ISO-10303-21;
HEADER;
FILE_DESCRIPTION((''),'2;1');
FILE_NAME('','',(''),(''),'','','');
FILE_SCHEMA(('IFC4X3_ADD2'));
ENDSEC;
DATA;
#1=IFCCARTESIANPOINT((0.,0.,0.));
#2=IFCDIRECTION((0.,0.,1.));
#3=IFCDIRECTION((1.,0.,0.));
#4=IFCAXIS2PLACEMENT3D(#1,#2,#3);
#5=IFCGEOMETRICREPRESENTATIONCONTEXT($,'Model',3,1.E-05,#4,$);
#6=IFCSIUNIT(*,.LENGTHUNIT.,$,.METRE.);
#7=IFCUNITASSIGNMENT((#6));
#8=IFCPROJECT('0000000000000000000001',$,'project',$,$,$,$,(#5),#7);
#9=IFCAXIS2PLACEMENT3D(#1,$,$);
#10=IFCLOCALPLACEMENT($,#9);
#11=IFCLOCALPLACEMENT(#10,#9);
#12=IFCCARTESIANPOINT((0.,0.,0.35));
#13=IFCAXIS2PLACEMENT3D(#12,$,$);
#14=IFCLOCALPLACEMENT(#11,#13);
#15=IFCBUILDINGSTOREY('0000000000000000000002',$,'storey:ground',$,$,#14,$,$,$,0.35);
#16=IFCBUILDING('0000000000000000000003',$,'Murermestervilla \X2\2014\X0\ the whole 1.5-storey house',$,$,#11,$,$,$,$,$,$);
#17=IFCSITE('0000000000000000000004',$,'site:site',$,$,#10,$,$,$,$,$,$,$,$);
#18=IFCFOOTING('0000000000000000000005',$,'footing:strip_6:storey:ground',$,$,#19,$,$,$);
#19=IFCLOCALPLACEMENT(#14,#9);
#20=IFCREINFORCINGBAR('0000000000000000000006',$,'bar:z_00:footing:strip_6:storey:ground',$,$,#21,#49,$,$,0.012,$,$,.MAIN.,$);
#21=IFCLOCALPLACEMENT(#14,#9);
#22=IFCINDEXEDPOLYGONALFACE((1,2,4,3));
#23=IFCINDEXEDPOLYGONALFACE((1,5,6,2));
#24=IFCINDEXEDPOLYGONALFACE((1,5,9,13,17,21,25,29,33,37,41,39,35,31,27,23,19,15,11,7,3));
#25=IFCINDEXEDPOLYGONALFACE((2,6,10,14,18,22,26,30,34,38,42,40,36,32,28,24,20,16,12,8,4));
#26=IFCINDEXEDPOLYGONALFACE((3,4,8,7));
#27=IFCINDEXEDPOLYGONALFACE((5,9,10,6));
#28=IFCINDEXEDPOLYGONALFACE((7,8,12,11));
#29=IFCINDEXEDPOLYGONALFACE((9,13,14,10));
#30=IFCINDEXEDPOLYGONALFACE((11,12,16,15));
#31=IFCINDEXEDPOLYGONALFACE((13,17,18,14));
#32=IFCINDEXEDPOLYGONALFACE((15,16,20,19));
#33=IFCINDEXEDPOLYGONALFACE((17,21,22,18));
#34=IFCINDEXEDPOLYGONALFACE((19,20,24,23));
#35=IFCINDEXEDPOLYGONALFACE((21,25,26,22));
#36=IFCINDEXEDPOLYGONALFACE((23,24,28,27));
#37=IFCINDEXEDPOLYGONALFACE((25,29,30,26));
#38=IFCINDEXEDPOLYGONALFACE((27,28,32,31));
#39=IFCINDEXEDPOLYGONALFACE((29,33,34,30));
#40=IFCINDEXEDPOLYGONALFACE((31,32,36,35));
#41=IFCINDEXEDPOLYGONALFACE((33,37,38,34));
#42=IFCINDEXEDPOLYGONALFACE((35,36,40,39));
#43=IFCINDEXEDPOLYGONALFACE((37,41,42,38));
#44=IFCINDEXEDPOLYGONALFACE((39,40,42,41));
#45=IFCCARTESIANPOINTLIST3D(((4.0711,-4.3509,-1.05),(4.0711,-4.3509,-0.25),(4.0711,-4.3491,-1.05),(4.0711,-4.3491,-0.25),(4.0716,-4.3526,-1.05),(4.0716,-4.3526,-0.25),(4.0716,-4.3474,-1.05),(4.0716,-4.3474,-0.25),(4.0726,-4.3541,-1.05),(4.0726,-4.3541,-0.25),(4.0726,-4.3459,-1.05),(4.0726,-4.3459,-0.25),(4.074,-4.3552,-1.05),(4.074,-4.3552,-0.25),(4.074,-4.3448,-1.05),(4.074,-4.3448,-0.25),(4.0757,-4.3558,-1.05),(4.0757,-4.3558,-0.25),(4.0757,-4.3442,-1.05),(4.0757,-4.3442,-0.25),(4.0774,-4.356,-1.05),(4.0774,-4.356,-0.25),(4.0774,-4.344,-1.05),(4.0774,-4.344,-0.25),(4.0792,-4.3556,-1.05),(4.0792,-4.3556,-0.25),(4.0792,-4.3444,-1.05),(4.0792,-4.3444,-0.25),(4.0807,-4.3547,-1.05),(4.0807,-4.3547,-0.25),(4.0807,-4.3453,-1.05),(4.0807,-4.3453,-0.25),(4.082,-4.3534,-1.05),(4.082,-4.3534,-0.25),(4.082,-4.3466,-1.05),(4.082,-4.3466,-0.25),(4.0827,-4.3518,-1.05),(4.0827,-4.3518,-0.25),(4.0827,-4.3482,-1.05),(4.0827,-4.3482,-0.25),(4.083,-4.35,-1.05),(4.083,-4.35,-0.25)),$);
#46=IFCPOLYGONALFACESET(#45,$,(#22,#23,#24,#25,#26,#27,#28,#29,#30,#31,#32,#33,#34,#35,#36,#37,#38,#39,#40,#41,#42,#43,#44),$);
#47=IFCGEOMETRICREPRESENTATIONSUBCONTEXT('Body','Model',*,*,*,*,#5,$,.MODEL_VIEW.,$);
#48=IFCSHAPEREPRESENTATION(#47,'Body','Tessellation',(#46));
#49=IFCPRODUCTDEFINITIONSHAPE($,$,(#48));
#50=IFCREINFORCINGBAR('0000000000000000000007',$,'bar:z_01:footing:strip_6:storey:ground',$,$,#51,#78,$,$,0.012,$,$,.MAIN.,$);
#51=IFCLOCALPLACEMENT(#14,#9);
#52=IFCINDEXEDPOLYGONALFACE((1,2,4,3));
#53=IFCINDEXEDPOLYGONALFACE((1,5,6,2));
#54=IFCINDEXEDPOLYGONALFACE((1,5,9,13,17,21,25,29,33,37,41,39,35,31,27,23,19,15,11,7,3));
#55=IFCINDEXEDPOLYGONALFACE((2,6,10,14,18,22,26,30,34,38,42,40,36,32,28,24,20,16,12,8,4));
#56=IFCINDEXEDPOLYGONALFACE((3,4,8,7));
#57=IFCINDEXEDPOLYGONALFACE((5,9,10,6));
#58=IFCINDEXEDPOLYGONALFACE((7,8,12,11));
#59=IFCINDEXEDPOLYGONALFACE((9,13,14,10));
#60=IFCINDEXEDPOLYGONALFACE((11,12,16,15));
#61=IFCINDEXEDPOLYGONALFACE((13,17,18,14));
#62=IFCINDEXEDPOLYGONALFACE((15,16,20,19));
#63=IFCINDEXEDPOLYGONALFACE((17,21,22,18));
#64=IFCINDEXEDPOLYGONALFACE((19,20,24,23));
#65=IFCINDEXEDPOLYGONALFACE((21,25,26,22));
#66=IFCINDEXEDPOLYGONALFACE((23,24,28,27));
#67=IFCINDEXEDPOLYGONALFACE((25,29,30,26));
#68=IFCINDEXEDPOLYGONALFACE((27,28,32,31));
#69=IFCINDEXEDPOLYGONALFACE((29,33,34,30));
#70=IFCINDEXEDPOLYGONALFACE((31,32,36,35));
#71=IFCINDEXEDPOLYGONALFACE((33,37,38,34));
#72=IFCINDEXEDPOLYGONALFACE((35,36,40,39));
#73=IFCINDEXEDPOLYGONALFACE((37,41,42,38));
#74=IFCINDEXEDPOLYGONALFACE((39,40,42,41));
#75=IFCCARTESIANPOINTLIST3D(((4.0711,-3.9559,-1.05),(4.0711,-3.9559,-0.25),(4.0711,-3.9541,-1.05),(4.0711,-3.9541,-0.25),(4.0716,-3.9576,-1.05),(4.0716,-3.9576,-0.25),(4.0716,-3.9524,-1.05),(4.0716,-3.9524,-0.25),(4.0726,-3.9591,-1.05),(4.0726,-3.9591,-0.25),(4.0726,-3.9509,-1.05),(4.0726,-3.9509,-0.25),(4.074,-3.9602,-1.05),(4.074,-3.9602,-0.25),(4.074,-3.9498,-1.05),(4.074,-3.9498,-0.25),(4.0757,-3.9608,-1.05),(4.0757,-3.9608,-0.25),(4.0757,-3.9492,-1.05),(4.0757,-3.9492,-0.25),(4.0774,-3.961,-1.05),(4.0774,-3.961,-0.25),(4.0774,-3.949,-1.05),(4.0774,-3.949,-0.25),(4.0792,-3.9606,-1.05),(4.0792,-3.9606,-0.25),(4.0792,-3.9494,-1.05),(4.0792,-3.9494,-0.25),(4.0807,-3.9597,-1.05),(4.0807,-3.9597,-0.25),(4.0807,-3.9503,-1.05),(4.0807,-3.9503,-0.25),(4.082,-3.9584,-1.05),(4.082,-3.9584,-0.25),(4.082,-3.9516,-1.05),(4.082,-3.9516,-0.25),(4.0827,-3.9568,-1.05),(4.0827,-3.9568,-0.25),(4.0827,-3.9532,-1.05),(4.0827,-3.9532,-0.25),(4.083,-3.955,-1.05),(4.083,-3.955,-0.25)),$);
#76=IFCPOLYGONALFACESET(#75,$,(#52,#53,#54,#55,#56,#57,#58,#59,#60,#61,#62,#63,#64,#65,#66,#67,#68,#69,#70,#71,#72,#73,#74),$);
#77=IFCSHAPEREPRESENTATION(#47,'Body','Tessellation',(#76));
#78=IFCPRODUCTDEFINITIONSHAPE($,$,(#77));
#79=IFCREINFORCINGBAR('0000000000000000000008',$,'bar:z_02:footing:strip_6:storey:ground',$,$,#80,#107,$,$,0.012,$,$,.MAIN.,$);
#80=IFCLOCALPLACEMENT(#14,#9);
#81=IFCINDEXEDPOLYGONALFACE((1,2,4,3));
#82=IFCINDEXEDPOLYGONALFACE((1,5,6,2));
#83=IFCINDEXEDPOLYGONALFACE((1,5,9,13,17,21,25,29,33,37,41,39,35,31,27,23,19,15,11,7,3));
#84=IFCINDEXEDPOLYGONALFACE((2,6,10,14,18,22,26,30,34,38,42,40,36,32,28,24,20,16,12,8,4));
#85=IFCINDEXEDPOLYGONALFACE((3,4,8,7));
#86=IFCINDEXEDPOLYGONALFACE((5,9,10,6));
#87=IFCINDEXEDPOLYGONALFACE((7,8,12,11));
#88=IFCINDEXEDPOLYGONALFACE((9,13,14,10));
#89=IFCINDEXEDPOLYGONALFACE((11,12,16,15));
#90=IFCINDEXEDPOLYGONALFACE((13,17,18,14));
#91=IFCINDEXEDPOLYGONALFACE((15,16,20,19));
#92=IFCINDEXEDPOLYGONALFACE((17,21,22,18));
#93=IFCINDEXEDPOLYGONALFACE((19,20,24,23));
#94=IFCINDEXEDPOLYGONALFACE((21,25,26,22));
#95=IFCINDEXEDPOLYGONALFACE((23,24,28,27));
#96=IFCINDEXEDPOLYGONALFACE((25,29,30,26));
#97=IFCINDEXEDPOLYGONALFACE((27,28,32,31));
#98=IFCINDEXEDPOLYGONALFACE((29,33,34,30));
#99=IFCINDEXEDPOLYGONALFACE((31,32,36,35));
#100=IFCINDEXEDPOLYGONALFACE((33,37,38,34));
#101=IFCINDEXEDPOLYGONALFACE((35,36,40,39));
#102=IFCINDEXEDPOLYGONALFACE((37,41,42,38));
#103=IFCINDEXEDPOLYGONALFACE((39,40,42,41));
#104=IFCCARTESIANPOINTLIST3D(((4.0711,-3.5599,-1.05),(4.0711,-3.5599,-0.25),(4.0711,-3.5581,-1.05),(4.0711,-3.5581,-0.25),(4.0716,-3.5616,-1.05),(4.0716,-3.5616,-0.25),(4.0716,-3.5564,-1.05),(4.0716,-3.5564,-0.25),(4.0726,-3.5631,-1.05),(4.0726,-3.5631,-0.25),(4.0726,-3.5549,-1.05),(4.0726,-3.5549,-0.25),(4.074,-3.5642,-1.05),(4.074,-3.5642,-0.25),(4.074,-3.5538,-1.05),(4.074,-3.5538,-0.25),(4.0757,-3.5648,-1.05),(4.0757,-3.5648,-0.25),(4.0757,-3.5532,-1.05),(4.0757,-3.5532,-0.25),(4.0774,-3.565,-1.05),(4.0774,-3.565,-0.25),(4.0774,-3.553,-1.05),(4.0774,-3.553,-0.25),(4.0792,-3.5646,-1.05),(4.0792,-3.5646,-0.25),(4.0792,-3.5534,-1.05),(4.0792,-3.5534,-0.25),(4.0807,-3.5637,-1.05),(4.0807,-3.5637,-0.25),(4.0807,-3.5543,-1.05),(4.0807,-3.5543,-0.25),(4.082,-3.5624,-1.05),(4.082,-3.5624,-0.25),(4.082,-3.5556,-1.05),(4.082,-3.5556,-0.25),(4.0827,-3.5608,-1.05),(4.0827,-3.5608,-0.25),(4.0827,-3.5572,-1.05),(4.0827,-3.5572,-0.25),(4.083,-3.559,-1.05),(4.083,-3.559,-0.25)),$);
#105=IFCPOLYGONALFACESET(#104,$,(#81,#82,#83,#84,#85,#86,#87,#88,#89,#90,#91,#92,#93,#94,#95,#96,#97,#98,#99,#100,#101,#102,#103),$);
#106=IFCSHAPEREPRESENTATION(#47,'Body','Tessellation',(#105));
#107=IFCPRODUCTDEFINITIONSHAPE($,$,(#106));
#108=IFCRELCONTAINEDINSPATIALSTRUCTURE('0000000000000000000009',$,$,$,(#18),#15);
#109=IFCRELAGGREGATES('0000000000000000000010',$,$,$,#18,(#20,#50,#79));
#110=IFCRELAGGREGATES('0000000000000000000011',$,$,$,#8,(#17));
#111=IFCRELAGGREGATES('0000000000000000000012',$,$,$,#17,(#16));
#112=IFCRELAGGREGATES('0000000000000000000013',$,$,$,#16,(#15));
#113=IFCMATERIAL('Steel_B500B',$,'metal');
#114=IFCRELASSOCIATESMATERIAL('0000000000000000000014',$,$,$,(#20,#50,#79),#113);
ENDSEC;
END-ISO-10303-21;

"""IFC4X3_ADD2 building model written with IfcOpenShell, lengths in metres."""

from ifc_helpers import new_model, entity, si_unit, frame, origin, origin_with_axes, place, context, subcontext, project, spatial, material, element, aggregate, save


model = new_model("IFC4X3_ADD2")

# Units and contexts
model_context = context("Model", 3, precision=1e-05, world=origin_with_axes())
body_context = subcontext(model_context, "Body", "Model", "MODEL_VIEW")
ifc_project = project(units=[si_unit("LENGTHUNIT", "METRE")], contexts=[model_context])

# Site, building, storey
placement_1 = place(None, origin())
site = spatial("IfcSite", under=ifc_project, at=placement_1, Name="site:site")
building_placement = place(placement_1, origin())
building = spatial("IfcBuilding", under=site, at=building_placement, Name="Murermestervilla — the whole 1.5-storey house")
storey_placement = place(building_placement, frame((0.0, 0.0, 0.35)))
storey = spatial("IfcBuildingStorey", under=building, at=storey_placement, Name="storey:ground", Elevation=0.35)

# Footing, reinforcing bars
placement_2 = place(storey_placement, frame((0.0, 0.0, -0.35)))
ifc_material = material(Name="Steel_B500B", Category="metal")
footing_1 = element("IfcFooting", 1, at=placement_2, inside=storey, Name="footing:strip_6:storey:ground")
reinforcing_bar_1 = element("IfcReinforcingBar", 2, at=placement_1, material=ifc_material, Name="bar:z_00:footing:strip_6:storey:ground", NominalDiameter=0.012, PredefinedType="MAIN", context=body_context, shape_type="AdvancedSweptSolid", body=[
    entity("IfcSweptDiskSolid", entity("IfcPolyline", [entity("IfcCartesianPoint", [4.077, -4.35, -0.7]), entity("IfcCartesianPoint", [4.077, -4.35, 0.1])]), 0.006),
])
reinforcing_bar_2 = element("IfcReinforcingBar", 3, at=placement_1, material=ifc_material, Name="bar:z_01:footing:strip_6:storey:ground", NominalDiameter=0.012, PredefinedType="MAIN", context=body_context, shape_type="AdvancedSweptSolid", body=[
    entity("IfcSweptDiskSolid", entity("IfcPolyline", [entity("IfcCartesianPoint", [4.077, -3.955, -0.7]), entity("IfcCartesianPoint", [4.077, -3.955, 0.1])]), 0.006),
])
reinforcing_bar_3 = element("IfcReinforcingBar", 4, at=placement_1, material=ifc_material, Name="bar:z_02:footing:strip_6:storey:ground", NominalDiameter=0.012, PredefinedType="MAIN", context=body_context, shape_type="AdvancedSweptSolid", body=[
    entity("IfcSweptDiskSolid", entity("IfcPolyline", [entity("IfcCartesianPoint", [4.077, -3.559, -0.7]), entity("IfcCartesianPoint", [4.077, -3.559, 0.1])]), 0.006),
])
aggregate(footing_1, [reinforcing_bar_1, reinforcing_bar_2, reinforcing_bar_3])

save(model, "model.ifc")
